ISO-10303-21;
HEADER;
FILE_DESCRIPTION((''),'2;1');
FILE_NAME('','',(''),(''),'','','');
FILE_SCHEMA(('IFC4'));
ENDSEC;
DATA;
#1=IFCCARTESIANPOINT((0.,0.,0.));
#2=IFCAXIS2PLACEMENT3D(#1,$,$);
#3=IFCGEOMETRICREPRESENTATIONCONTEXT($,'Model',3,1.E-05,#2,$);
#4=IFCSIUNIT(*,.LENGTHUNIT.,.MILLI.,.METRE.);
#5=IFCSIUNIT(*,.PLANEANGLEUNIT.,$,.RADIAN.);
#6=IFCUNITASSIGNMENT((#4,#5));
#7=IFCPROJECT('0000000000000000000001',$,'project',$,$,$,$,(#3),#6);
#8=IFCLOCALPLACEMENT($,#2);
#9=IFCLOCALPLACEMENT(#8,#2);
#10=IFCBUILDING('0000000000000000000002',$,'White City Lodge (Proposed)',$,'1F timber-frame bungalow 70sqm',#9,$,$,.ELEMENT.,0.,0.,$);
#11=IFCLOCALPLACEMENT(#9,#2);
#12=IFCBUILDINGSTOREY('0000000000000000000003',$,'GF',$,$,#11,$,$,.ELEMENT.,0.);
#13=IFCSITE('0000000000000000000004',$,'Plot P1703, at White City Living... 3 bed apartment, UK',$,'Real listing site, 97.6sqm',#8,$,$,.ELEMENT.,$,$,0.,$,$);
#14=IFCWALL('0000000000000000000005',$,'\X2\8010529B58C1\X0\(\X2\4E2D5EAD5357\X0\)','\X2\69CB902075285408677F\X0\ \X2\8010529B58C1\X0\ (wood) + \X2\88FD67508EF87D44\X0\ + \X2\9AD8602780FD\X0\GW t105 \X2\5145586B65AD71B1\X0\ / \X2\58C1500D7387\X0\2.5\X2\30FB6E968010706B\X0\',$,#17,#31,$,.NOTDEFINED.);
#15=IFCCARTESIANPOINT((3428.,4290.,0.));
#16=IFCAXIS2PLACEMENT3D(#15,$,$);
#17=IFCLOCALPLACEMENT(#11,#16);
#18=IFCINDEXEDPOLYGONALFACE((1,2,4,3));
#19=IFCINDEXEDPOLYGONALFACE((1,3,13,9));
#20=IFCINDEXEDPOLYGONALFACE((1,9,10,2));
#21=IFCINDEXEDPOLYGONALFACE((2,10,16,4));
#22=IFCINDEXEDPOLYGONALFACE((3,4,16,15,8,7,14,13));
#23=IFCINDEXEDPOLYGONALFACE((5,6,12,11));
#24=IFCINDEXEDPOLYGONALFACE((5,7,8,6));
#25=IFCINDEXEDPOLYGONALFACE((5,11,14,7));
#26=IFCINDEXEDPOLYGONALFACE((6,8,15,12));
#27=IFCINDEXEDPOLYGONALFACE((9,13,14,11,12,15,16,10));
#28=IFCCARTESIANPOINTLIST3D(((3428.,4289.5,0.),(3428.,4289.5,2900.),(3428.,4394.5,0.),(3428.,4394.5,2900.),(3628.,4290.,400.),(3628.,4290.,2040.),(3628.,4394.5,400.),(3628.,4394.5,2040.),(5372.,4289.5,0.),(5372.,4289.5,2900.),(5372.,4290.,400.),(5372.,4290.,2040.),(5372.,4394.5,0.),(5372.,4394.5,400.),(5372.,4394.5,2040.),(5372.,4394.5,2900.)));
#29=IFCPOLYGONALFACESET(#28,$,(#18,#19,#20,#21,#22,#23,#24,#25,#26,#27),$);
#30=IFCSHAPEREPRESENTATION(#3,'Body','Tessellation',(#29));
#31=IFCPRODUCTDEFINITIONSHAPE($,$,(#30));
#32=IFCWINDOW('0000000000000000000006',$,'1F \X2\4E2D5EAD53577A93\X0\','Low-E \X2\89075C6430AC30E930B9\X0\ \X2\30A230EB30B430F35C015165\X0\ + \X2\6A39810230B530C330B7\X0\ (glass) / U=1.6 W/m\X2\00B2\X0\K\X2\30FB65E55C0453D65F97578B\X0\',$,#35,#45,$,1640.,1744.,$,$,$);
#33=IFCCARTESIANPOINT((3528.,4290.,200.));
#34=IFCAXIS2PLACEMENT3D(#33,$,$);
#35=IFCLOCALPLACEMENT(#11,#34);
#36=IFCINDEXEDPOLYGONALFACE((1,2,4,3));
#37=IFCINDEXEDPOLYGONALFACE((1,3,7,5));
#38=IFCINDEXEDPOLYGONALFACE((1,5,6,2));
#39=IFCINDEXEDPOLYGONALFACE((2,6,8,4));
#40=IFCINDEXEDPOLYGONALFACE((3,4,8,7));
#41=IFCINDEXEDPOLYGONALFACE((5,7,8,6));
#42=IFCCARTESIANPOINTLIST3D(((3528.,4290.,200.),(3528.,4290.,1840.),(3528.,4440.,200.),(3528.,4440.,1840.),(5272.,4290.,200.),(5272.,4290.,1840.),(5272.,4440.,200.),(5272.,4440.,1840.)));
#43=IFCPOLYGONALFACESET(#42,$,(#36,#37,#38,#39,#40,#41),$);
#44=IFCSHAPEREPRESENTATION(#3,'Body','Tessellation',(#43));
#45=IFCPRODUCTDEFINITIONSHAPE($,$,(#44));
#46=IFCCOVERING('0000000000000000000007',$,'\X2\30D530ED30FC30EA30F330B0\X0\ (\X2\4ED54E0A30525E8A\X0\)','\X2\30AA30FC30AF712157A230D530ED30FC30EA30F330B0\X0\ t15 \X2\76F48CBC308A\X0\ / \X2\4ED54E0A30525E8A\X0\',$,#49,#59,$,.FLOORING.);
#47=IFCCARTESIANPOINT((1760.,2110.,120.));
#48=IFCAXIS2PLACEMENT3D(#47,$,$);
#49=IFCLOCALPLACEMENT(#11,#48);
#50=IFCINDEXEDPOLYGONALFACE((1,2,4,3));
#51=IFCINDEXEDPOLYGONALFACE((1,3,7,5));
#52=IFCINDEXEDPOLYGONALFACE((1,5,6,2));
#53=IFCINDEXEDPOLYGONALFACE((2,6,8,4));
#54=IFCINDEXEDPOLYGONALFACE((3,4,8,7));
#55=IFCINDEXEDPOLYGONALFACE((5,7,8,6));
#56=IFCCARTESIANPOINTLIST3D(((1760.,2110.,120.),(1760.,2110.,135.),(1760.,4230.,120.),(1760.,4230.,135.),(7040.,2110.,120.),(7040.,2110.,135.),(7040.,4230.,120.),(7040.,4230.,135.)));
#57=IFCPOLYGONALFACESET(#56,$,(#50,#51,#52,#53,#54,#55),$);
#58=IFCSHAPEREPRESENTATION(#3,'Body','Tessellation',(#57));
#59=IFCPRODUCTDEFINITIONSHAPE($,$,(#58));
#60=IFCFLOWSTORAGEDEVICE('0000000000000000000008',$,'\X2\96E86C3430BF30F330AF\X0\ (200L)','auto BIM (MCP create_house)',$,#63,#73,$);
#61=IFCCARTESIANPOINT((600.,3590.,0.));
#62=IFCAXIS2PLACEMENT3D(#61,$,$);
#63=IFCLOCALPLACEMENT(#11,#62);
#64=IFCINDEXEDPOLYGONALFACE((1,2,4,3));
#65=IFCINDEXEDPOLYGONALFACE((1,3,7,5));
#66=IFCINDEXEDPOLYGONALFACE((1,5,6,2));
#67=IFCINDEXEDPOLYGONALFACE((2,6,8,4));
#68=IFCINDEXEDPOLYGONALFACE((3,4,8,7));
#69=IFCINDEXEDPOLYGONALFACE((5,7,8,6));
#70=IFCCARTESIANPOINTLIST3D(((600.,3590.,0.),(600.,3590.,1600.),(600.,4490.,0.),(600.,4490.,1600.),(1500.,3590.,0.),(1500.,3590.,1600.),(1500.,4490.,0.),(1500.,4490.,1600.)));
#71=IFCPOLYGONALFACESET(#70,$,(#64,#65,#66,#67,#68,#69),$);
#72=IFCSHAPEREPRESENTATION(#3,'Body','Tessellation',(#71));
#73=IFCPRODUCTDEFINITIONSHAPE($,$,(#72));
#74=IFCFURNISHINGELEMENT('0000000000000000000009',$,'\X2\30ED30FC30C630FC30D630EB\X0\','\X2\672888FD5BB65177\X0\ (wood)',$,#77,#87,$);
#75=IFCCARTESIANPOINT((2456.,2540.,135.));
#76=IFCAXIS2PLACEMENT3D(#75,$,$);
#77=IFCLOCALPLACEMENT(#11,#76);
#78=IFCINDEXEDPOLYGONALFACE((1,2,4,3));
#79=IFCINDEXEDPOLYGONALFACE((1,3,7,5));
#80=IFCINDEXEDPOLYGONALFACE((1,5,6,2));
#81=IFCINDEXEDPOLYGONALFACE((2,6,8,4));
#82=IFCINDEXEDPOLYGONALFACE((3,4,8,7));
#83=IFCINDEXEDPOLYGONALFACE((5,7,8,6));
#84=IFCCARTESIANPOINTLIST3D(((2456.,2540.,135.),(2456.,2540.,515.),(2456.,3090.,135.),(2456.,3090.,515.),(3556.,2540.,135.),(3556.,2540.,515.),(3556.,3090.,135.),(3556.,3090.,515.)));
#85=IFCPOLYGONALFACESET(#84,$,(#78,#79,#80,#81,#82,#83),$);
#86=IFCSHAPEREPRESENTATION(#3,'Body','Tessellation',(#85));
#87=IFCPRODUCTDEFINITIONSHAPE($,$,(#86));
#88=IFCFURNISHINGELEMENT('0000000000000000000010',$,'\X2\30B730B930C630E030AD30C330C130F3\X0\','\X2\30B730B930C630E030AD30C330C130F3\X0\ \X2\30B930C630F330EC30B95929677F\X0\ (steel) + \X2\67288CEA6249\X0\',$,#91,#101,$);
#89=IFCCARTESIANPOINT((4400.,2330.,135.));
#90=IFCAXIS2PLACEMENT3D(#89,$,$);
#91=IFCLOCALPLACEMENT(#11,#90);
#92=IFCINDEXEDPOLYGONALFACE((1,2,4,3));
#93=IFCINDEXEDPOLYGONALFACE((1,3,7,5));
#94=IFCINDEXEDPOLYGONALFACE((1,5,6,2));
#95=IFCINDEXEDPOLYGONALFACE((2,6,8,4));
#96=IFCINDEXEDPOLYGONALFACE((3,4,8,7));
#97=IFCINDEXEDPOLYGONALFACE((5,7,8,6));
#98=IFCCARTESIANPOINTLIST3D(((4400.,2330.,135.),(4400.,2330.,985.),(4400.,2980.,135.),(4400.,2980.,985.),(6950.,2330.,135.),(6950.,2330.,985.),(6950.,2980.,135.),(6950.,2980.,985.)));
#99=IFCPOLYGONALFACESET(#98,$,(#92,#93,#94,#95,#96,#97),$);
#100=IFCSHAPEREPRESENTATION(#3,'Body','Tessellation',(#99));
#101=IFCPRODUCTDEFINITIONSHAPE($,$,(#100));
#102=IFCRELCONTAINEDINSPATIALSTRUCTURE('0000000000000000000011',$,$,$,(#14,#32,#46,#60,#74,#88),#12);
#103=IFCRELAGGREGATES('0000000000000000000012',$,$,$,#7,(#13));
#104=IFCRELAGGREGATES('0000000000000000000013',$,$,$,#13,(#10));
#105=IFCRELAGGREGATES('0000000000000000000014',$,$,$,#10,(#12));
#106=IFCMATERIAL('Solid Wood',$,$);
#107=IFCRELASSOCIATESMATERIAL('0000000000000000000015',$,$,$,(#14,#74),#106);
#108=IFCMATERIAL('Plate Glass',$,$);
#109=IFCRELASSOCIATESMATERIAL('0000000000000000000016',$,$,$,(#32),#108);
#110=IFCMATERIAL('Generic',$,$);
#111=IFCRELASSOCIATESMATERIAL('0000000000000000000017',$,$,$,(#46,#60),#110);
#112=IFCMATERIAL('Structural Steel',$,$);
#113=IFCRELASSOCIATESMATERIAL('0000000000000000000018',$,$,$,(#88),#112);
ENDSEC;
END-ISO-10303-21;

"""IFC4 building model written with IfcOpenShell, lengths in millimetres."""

from ifc_helpers import new_model, si_unit, frame, frame_2d, origin, place, context, project, spatial, rectangle, extrude, material, element, fill, save


model = new_model("IFC4")

# Units and contexts
model_context = context("Model", 3, precision=1e-05, world=origin())
ifc_project = project(units=[si_unit("LENGTHUNIT", "METRE", prefix="MILLI"), si_unit("PLANEANGLEUNIT", "RADIAN")], contexts=[model_context])

# Site, building, storey
site_placement = place(None, origin())
site = spatial("IfcSite", under=ifc_project, at=site_placement, Name="Plot P1703, at White City Living... 3 bed apartment, UK", ObjectType="Real listing site, 97.6sqm", CompositionType="ELEMENT", RefElevation=0.0)
building_placement = place(site_placement, origin())
building = spatial("IfcBuilding", under=site, at=building_placement, Name="White City Lodge (Proposed)", ObjectType="1F timber-frame bungalow 70sqm", CompositionType="ELEMENT", ElevationOfRefHeight=0.0, ElevationOfTerrain=0.0)
storey_placement = place(building_placement, origin())
storey = spatial("IfcBuildingStorey", under=building, at=storey_placement, Name="GF", CompositionType="ELEMENT", Elevation=0.0)

# Shared definitions
ifc_material_1 = material(Name="Solid Wood")

# Shared definitions
ifc_material_2 = material(Name="Plate Glass")

# Wall, opening, window
wall_1_placement = place(storey_placement, frame((3428.0, 4290.0, 0.0)))
wall_1 = element("IfcWall", 1, at=wall_1_placement, inside=storey, material=ifc_material_1, Name="耐力壁(中庭南)", Description="構造用合板 耐力壁 (wood) + 製材軸組 + 高性能GW t105 充填断熱 / 壁倍率2.5・準耐火", PredefinedType="NOTDEFINED", context=model_context, shape_type="SweptSolid", body=[
    extrude(rectangle(XDim=1944.0, YDim=105.0, at=frame_2d((972.0, 52.0))), frame((3428.0, 4290.0, 0.0)), (0.0, 0.0, 1.0), 2900.0),
])
opening_1_placement = place(storey_placement, frame((3528.0, 4290.0, 200.0)))
opening_1 = element("IfcOpeningElement", 2, at=opening_1_placement, cuts=wall_1, PredefinedType="NOTDEFINED", context=model_context, shape_type="SweptSolid", body=[
    extrude(rectangle(XDim=1744.0, YDim=150.0, at=frame_2d((872.0, 75.0))), frame((3528.0, 4290.0, 200.0)), (0.0, 0.0, 1.0), 1640.0),
])
window_1_placement = place(storey_placement, frame((3528.0, 4290.0, 200.0)))
window_1 = element("IfcWindow", 3, at=window_1_placement, inside=storey, material=ifc_material_2, Name="1F 中庭南窓", Description="Low-E 複層ガラス アルゴン封入 + 樹脂サッシ (glass) / U=1.6 W/m²K・日射取得型", OverallHeight=1640.0, OverallWidth=1744.0, context=model_context, shape_type="SweptSolid", body=[
    extrude(rectangle(XDim=1744.0, YDim=150.0, at=frame_2d((872.0, 75.0))), frame((3528.0, 4290.0, 200.0)), (0.0, 0.0, 1.0), 1640.0),
])
fill(opening_1, window_1)

# Covering
ifc_material_3 = material(Name="Generic")
covering_placement = place(storey_placement, frame((1760.0, 2110.0, 120.0)))
element("IfcCovering", 4, at=covering_placement, inside=storey, material=ifc_material_3, Name="フローリング (仕上げ床)", Description="オーク無垢フローリング t15 直貼り / 仕上げ床", PredefinedType="FLOORING", context=model_context, shape_type="SweptSolid", body=[
    extrude(rectangle(XDim=5280.0, YDim=2120.0, at=frame_2d((2640.0, 1060.0))), frame((1760.0, 2110.0, 120.0)), (0.0, 0.0, 1.0), 15.0),
])

# Flow storage device
flow_storage_device_placement = place(storey_placement, frame((600.0, 3590.0, 0.0)))
element("IfcFlowStorageDevice", 5, at=flow_storage_device_placement, inside=storey, material=ifc_material_3, Name="雨水タンク (200L)", Description="auto BIM (MCP create_house)", context=model_context, shape_type="SweptSolid", body=[
    extrude(rectangle(XDim=900.0, YDim=900.0, at=frame_2d((450.0, 450.0))), frame((600.0, 3590.0, 0.0)), (0.0, 0.0, 1.0), 1600.0),
])

# Furnishing elements
furnishing_1_placement = place(storey_placement, frame((2456.0, 2540.0, 135.0)))
element("IfcFurnishingElement", 6, at=furnishing_1_placement, inside=storey, material=ifc_material_1, Name="ローテーブル", Description="木製家具 (wood)", context=model_context, shape_type="SweptSolid", body=[
    extrude(rectangle(XDim=1100.0, YDim=550.0, at=frame_2d((550.0, 275.0))), frame((2456.0, 2540.0, 135.0)), (0.0, 0.0, 1.0), 380.0),
])
ifc_material_4 = material(Name="Structural Steel")
furnishing_2_placement = place(storey_placement, frame((4400.0, 2330.0, 135.0)))
element("IfcFurnishingElement", 7, at=furnishing_2_placement, inside=storey, material=ifc_material_4, Name="システムキッチン", Description="システムキッチン ステンレス天板 (steel) + 木質扉", context=model_context, shape_type="SweptSolid", body=[
    extrude(rectangle(XDim=2550.0, YDim=650.0, at=frame_2d((1275.0, 325.0))), frame((4400.0, 2330.0, 135.0)), (0.0, 0.0, 1.0), 850.0),
])

save(model, "model.ifc")
